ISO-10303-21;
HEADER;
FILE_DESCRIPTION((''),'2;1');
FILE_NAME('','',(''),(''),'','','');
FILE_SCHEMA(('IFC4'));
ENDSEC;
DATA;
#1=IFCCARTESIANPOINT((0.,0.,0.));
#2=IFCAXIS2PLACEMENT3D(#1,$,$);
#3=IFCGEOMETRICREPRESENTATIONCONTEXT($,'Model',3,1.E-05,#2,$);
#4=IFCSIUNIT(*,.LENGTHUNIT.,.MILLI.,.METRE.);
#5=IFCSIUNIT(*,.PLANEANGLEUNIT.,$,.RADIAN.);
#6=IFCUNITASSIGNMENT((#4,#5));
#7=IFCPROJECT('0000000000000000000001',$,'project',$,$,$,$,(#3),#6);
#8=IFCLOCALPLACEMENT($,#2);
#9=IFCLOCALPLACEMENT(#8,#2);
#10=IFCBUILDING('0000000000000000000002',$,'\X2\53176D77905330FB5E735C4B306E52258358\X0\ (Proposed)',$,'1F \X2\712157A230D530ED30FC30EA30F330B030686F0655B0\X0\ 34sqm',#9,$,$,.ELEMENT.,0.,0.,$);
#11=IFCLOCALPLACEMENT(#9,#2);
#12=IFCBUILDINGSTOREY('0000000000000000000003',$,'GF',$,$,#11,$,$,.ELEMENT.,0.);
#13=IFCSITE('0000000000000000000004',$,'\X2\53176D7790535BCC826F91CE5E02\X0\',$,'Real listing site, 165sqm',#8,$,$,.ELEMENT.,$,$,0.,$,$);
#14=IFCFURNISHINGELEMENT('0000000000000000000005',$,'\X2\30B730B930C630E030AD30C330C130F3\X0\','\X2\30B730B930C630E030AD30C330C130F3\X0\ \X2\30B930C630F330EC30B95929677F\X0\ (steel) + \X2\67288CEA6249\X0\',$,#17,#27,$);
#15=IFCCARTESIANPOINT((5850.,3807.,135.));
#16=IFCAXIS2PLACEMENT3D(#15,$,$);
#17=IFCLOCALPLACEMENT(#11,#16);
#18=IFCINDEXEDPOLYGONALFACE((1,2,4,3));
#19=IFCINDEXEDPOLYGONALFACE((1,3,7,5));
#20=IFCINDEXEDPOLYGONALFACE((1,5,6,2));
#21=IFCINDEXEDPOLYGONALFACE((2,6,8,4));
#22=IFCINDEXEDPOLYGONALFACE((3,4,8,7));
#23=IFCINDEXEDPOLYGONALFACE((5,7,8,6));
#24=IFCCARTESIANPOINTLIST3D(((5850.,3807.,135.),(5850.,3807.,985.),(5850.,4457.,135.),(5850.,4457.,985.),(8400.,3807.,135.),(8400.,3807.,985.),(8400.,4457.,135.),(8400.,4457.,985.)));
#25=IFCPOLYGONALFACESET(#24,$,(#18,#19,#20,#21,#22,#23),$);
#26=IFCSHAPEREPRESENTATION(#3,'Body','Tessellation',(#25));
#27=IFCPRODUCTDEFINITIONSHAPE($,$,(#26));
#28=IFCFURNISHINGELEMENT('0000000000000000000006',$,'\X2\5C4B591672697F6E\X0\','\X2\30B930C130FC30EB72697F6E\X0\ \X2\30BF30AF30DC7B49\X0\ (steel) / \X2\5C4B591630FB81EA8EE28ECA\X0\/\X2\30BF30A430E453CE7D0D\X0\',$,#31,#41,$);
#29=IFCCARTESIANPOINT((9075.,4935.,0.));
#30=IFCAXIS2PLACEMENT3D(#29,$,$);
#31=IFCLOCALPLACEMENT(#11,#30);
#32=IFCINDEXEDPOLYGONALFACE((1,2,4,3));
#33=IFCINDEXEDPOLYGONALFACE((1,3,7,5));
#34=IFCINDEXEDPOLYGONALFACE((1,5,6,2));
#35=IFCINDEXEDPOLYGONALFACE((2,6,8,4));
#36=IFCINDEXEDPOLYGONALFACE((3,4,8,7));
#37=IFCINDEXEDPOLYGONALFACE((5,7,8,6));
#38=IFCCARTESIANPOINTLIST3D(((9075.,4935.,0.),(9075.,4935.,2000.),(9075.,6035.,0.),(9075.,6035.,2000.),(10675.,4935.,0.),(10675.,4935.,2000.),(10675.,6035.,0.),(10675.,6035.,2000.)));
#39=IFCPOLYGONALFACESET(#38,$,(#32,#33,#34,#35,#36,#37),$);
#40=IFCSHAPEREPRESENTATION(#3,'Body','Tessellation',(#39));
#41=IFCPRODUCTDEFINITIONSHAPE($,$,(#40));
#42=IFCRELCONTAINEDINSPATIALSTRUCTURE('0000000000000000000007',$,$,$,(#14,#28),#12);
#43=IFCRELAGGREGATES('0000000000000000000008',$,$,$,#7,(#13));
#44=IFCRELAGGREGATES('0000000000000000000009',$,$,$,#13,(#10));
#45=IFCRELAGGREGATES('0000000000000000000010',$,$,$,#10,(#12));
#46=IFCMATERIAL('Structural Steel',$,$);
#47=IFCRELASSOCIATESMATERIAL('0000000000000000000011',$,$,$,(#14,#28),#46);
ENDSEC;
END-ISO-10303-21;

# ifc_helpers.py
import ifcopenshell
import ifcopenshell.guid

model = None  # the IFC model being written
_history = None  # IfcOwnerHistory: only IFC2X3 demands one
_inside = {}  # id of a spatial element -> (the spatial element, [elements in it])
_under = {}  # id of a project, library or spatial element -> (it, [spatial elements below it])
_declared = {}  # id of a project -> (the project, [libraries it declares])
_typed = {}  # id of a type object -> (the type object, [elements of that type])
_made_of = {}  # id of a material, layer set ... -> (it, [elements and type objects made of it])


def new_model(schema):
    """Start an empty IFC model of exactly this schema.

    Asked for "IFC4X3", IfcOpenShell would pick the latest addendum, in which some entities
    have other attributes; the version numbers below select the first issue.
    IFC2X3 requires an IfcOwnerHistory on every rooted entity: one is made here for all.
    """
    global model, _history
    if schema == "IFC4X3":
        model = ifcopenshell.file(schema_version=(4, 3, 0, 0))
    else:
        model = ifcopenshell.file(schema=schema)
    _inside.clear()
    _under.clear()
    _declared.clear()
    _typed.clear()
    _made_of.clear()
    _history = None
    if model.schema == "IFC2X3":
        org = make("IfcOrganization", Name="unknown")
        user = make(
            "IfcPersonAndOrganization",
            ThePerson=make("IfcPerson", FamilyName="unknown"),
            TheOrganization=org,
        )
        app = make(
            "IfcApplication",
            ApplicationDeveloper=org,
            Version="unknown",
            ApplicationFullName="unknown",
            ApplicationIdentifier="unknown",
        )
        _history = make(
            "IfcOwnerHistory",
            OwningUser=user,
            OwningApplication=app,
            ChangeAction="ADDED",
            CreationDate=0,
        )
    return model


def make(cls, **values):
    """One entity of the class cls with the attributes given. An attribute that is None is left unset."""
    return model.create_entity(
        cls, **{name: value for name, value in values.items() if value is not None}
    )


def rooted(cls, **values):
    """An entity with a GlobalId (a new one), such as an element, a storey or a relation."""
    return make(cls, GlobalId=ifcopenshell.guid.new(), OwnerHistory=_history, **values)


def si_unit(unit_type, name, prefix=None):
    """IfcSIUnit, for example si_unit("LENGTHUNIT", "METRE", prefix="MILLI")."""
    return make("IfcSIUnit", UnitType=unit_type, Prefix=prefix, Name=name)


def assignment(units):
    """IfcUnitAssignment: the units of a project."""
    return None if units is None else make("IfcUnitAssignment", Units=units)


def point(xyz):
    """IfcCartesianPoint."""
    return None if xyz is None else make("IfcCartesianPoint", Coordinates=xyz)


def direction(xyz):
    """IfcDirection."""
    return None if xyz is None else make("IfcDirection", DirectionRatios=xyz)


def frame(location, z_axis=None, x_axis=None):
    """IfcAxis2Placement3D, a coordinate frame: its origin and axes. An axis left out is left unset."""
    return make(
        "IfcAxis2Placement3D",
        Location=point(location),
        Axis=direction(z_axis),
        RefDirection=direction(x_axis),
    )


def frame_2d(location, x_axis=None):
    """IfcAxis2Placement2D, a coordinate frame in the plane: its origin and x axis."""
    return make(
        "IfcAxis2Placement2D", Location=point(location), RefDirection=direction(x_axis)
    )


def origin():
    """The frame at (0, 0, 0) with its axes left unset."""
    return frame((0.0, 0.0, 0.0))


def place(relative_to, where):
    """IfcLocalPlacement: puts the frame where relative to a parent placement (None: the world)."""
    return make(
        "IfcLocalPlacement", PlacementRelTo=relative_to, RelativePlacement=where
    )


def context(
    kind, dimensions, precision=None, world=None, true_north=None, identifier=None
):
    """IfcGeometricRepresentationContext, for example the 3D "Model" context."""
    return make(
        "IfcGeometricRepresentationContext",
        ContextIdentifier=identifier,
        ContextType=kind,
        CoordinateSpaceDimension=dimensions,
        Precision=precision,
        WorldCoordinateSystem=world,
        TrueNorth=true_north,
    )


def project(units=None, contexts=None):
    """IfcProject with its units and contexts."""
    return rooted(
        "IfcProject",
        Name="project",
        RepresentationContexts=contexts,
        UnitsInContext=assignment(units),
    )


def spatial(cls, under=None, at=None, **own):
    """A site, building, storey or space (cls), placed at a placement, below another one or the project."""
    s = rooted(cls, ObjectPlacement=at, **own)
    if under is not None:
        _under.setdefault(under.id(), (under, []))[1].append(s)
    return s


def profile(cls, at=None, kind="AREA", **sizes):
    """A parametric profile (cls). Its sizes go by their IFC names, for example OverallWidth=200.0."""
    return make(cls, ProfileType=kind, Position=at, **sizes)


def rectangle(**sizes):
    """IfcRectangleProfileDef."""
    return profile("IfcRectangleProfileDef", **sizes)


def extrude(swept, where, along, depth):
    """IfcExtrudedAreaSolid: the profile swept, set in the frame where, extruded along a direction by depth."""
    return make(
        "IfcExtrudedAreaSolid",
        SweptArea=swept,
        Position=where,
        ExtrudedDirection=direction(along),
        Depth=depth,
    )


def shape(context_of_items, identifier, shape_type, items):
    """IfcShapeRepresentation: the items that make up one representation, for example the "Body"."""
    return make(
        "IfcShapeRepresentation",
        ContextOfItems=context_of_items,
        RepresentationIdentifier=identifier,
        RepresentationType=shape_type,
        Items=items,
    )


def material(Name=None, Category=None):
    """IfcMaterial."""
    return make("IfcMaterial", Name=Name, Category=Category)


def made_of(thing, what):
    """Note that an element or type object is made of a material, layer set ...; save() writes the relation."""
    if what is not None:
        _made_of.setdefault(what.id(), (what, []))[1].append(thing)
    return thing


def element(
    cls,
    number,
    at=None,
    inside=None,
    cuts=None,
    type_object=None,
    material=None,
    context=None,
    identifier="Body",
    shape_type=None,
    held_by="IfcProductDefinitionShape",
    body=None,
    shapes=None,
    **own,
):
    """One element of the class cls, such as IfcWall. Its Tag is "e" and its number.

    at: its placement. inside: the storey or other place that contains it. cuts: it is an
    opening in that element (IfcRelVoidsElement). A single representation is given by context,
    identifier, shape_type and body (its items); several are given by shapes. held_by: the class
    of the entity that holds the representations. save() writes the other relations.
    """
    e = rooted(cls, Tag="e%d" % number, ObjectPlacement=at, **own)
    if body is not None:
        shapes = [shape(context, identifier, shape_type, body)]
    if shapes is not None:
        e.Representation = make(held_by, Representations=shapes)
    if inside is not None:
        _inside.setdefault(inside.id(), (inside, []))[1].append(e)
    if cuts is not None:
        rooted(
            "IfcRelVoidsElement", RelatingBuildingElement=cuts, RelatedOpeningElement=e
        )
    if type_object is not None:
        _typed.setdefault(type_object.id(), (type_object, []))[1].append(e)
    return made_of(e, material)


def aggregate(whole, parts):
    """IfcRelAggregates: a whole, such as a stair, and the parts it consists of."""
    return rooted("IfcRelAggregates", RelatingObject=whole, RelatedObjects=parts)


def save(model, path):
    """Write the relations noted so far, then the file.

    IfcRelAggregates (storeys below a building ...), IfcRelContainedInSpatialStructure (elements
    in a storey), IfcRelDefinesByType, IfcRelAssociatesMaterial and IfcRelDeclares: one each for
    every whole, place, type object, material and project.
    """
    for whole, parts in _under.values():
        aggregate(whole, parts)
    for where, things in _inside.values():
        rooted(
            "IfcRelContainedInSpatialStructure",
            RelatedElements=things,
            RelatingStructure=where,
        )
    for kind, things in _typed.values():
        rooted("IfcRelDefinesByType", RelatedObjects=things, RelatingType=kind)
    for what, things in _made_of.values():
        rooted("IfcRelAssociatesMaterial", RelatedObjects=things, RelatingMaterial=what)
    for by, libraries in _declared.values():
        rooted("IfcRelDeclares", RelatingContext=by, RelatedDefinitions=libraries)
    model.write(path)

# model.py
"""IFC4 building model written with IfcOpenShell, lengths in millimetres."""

from ifc_helpers import new_model, si_unit, frame, frame_2d, origin, place, context, project, spatial, rectangle, extrude, material, element, save


model = new_model("IFC4")

# Units and contexts
model_context = context("Model", 3, precision=1e-05, world=origin())
ifc_project = project(units=[si_unit("LENGTHUNIT", "METRE", prefix="MILLI"), si_unit("PLANEANGLEUNIT", "RADIAN")], contexts=[model_context])

# Site, building, storey
site_placement = place(None, origin())
site = spatial("IfcSite", under=ifc_project, at=site_placement, Name="北海道富良野市", ObjectType="Real listing site, 165sqm", CompositionType="ELEMENT", RefElevation=0.0)
building_placement = place(site_placement, origin())
building = spatial("IfcBuilding", under=site, at=building_placement, Name="北海道・平屋の別荘 (Proposed)", ObjectType="1F 無垢フローリングと漆喰 34sqm", CompositionType="ELEMENT", ElevationOfRefHeight=0.0, ElevationOfTerrain=0.0)
storey_placement = place(building_placement, origin())
storey = spatial("IfcBuildingStorey", under=building, at=storey_placement, Name="GF", CompositionType="ELEMENT", Elevation=0.0)

# Shared definitions
ifc_material_1 = material(Name="Structural Steel")

# Furnishing elements
furnishing_1_placement = place(storey_placement, frame((5850.0, 3807.0, 135.0)))
element("IfcFurnishingElement", 1, at=furnishing_1_placement, inside=storey, material=ifc_material_1, Name="システムキッチン", Description="システムキッチン ステンレス天板 (steel) + 木質扉", context=model_context, shape_type="SweptSolid", body=[
    extrude(rectangle(XDim=2550.0, YDim=650.0, at=frame_2d((1275.0, 325.0))), frame((5850.0, 3807.0, 135.0)), (0.0, 0.0, 1.0), 850.0),
])
furnishing_2_placement = place(storey_placement, frame((9075.0, 4935.0, 0.0)))
element("IfcFurnishingElement", 2, at=furnishing_2_placement, inside=storey, material=ifc_material_1, Name="屋外物置", Description="スチール物置 タクボ等 (steel) / 屋外・自転車/タイヤ収納", context=model_context, shape_type="SweptSolid", body=[
    extrude(rectangle(XDim=1600.0, YDim=1100.0, at=frame_2d((800.0, 550.0))), frame((9075.0, 4935.0, 0.0)), (0.0, 0.0, 1.0), 2000.0),
])

save(model, "model.ifc")
